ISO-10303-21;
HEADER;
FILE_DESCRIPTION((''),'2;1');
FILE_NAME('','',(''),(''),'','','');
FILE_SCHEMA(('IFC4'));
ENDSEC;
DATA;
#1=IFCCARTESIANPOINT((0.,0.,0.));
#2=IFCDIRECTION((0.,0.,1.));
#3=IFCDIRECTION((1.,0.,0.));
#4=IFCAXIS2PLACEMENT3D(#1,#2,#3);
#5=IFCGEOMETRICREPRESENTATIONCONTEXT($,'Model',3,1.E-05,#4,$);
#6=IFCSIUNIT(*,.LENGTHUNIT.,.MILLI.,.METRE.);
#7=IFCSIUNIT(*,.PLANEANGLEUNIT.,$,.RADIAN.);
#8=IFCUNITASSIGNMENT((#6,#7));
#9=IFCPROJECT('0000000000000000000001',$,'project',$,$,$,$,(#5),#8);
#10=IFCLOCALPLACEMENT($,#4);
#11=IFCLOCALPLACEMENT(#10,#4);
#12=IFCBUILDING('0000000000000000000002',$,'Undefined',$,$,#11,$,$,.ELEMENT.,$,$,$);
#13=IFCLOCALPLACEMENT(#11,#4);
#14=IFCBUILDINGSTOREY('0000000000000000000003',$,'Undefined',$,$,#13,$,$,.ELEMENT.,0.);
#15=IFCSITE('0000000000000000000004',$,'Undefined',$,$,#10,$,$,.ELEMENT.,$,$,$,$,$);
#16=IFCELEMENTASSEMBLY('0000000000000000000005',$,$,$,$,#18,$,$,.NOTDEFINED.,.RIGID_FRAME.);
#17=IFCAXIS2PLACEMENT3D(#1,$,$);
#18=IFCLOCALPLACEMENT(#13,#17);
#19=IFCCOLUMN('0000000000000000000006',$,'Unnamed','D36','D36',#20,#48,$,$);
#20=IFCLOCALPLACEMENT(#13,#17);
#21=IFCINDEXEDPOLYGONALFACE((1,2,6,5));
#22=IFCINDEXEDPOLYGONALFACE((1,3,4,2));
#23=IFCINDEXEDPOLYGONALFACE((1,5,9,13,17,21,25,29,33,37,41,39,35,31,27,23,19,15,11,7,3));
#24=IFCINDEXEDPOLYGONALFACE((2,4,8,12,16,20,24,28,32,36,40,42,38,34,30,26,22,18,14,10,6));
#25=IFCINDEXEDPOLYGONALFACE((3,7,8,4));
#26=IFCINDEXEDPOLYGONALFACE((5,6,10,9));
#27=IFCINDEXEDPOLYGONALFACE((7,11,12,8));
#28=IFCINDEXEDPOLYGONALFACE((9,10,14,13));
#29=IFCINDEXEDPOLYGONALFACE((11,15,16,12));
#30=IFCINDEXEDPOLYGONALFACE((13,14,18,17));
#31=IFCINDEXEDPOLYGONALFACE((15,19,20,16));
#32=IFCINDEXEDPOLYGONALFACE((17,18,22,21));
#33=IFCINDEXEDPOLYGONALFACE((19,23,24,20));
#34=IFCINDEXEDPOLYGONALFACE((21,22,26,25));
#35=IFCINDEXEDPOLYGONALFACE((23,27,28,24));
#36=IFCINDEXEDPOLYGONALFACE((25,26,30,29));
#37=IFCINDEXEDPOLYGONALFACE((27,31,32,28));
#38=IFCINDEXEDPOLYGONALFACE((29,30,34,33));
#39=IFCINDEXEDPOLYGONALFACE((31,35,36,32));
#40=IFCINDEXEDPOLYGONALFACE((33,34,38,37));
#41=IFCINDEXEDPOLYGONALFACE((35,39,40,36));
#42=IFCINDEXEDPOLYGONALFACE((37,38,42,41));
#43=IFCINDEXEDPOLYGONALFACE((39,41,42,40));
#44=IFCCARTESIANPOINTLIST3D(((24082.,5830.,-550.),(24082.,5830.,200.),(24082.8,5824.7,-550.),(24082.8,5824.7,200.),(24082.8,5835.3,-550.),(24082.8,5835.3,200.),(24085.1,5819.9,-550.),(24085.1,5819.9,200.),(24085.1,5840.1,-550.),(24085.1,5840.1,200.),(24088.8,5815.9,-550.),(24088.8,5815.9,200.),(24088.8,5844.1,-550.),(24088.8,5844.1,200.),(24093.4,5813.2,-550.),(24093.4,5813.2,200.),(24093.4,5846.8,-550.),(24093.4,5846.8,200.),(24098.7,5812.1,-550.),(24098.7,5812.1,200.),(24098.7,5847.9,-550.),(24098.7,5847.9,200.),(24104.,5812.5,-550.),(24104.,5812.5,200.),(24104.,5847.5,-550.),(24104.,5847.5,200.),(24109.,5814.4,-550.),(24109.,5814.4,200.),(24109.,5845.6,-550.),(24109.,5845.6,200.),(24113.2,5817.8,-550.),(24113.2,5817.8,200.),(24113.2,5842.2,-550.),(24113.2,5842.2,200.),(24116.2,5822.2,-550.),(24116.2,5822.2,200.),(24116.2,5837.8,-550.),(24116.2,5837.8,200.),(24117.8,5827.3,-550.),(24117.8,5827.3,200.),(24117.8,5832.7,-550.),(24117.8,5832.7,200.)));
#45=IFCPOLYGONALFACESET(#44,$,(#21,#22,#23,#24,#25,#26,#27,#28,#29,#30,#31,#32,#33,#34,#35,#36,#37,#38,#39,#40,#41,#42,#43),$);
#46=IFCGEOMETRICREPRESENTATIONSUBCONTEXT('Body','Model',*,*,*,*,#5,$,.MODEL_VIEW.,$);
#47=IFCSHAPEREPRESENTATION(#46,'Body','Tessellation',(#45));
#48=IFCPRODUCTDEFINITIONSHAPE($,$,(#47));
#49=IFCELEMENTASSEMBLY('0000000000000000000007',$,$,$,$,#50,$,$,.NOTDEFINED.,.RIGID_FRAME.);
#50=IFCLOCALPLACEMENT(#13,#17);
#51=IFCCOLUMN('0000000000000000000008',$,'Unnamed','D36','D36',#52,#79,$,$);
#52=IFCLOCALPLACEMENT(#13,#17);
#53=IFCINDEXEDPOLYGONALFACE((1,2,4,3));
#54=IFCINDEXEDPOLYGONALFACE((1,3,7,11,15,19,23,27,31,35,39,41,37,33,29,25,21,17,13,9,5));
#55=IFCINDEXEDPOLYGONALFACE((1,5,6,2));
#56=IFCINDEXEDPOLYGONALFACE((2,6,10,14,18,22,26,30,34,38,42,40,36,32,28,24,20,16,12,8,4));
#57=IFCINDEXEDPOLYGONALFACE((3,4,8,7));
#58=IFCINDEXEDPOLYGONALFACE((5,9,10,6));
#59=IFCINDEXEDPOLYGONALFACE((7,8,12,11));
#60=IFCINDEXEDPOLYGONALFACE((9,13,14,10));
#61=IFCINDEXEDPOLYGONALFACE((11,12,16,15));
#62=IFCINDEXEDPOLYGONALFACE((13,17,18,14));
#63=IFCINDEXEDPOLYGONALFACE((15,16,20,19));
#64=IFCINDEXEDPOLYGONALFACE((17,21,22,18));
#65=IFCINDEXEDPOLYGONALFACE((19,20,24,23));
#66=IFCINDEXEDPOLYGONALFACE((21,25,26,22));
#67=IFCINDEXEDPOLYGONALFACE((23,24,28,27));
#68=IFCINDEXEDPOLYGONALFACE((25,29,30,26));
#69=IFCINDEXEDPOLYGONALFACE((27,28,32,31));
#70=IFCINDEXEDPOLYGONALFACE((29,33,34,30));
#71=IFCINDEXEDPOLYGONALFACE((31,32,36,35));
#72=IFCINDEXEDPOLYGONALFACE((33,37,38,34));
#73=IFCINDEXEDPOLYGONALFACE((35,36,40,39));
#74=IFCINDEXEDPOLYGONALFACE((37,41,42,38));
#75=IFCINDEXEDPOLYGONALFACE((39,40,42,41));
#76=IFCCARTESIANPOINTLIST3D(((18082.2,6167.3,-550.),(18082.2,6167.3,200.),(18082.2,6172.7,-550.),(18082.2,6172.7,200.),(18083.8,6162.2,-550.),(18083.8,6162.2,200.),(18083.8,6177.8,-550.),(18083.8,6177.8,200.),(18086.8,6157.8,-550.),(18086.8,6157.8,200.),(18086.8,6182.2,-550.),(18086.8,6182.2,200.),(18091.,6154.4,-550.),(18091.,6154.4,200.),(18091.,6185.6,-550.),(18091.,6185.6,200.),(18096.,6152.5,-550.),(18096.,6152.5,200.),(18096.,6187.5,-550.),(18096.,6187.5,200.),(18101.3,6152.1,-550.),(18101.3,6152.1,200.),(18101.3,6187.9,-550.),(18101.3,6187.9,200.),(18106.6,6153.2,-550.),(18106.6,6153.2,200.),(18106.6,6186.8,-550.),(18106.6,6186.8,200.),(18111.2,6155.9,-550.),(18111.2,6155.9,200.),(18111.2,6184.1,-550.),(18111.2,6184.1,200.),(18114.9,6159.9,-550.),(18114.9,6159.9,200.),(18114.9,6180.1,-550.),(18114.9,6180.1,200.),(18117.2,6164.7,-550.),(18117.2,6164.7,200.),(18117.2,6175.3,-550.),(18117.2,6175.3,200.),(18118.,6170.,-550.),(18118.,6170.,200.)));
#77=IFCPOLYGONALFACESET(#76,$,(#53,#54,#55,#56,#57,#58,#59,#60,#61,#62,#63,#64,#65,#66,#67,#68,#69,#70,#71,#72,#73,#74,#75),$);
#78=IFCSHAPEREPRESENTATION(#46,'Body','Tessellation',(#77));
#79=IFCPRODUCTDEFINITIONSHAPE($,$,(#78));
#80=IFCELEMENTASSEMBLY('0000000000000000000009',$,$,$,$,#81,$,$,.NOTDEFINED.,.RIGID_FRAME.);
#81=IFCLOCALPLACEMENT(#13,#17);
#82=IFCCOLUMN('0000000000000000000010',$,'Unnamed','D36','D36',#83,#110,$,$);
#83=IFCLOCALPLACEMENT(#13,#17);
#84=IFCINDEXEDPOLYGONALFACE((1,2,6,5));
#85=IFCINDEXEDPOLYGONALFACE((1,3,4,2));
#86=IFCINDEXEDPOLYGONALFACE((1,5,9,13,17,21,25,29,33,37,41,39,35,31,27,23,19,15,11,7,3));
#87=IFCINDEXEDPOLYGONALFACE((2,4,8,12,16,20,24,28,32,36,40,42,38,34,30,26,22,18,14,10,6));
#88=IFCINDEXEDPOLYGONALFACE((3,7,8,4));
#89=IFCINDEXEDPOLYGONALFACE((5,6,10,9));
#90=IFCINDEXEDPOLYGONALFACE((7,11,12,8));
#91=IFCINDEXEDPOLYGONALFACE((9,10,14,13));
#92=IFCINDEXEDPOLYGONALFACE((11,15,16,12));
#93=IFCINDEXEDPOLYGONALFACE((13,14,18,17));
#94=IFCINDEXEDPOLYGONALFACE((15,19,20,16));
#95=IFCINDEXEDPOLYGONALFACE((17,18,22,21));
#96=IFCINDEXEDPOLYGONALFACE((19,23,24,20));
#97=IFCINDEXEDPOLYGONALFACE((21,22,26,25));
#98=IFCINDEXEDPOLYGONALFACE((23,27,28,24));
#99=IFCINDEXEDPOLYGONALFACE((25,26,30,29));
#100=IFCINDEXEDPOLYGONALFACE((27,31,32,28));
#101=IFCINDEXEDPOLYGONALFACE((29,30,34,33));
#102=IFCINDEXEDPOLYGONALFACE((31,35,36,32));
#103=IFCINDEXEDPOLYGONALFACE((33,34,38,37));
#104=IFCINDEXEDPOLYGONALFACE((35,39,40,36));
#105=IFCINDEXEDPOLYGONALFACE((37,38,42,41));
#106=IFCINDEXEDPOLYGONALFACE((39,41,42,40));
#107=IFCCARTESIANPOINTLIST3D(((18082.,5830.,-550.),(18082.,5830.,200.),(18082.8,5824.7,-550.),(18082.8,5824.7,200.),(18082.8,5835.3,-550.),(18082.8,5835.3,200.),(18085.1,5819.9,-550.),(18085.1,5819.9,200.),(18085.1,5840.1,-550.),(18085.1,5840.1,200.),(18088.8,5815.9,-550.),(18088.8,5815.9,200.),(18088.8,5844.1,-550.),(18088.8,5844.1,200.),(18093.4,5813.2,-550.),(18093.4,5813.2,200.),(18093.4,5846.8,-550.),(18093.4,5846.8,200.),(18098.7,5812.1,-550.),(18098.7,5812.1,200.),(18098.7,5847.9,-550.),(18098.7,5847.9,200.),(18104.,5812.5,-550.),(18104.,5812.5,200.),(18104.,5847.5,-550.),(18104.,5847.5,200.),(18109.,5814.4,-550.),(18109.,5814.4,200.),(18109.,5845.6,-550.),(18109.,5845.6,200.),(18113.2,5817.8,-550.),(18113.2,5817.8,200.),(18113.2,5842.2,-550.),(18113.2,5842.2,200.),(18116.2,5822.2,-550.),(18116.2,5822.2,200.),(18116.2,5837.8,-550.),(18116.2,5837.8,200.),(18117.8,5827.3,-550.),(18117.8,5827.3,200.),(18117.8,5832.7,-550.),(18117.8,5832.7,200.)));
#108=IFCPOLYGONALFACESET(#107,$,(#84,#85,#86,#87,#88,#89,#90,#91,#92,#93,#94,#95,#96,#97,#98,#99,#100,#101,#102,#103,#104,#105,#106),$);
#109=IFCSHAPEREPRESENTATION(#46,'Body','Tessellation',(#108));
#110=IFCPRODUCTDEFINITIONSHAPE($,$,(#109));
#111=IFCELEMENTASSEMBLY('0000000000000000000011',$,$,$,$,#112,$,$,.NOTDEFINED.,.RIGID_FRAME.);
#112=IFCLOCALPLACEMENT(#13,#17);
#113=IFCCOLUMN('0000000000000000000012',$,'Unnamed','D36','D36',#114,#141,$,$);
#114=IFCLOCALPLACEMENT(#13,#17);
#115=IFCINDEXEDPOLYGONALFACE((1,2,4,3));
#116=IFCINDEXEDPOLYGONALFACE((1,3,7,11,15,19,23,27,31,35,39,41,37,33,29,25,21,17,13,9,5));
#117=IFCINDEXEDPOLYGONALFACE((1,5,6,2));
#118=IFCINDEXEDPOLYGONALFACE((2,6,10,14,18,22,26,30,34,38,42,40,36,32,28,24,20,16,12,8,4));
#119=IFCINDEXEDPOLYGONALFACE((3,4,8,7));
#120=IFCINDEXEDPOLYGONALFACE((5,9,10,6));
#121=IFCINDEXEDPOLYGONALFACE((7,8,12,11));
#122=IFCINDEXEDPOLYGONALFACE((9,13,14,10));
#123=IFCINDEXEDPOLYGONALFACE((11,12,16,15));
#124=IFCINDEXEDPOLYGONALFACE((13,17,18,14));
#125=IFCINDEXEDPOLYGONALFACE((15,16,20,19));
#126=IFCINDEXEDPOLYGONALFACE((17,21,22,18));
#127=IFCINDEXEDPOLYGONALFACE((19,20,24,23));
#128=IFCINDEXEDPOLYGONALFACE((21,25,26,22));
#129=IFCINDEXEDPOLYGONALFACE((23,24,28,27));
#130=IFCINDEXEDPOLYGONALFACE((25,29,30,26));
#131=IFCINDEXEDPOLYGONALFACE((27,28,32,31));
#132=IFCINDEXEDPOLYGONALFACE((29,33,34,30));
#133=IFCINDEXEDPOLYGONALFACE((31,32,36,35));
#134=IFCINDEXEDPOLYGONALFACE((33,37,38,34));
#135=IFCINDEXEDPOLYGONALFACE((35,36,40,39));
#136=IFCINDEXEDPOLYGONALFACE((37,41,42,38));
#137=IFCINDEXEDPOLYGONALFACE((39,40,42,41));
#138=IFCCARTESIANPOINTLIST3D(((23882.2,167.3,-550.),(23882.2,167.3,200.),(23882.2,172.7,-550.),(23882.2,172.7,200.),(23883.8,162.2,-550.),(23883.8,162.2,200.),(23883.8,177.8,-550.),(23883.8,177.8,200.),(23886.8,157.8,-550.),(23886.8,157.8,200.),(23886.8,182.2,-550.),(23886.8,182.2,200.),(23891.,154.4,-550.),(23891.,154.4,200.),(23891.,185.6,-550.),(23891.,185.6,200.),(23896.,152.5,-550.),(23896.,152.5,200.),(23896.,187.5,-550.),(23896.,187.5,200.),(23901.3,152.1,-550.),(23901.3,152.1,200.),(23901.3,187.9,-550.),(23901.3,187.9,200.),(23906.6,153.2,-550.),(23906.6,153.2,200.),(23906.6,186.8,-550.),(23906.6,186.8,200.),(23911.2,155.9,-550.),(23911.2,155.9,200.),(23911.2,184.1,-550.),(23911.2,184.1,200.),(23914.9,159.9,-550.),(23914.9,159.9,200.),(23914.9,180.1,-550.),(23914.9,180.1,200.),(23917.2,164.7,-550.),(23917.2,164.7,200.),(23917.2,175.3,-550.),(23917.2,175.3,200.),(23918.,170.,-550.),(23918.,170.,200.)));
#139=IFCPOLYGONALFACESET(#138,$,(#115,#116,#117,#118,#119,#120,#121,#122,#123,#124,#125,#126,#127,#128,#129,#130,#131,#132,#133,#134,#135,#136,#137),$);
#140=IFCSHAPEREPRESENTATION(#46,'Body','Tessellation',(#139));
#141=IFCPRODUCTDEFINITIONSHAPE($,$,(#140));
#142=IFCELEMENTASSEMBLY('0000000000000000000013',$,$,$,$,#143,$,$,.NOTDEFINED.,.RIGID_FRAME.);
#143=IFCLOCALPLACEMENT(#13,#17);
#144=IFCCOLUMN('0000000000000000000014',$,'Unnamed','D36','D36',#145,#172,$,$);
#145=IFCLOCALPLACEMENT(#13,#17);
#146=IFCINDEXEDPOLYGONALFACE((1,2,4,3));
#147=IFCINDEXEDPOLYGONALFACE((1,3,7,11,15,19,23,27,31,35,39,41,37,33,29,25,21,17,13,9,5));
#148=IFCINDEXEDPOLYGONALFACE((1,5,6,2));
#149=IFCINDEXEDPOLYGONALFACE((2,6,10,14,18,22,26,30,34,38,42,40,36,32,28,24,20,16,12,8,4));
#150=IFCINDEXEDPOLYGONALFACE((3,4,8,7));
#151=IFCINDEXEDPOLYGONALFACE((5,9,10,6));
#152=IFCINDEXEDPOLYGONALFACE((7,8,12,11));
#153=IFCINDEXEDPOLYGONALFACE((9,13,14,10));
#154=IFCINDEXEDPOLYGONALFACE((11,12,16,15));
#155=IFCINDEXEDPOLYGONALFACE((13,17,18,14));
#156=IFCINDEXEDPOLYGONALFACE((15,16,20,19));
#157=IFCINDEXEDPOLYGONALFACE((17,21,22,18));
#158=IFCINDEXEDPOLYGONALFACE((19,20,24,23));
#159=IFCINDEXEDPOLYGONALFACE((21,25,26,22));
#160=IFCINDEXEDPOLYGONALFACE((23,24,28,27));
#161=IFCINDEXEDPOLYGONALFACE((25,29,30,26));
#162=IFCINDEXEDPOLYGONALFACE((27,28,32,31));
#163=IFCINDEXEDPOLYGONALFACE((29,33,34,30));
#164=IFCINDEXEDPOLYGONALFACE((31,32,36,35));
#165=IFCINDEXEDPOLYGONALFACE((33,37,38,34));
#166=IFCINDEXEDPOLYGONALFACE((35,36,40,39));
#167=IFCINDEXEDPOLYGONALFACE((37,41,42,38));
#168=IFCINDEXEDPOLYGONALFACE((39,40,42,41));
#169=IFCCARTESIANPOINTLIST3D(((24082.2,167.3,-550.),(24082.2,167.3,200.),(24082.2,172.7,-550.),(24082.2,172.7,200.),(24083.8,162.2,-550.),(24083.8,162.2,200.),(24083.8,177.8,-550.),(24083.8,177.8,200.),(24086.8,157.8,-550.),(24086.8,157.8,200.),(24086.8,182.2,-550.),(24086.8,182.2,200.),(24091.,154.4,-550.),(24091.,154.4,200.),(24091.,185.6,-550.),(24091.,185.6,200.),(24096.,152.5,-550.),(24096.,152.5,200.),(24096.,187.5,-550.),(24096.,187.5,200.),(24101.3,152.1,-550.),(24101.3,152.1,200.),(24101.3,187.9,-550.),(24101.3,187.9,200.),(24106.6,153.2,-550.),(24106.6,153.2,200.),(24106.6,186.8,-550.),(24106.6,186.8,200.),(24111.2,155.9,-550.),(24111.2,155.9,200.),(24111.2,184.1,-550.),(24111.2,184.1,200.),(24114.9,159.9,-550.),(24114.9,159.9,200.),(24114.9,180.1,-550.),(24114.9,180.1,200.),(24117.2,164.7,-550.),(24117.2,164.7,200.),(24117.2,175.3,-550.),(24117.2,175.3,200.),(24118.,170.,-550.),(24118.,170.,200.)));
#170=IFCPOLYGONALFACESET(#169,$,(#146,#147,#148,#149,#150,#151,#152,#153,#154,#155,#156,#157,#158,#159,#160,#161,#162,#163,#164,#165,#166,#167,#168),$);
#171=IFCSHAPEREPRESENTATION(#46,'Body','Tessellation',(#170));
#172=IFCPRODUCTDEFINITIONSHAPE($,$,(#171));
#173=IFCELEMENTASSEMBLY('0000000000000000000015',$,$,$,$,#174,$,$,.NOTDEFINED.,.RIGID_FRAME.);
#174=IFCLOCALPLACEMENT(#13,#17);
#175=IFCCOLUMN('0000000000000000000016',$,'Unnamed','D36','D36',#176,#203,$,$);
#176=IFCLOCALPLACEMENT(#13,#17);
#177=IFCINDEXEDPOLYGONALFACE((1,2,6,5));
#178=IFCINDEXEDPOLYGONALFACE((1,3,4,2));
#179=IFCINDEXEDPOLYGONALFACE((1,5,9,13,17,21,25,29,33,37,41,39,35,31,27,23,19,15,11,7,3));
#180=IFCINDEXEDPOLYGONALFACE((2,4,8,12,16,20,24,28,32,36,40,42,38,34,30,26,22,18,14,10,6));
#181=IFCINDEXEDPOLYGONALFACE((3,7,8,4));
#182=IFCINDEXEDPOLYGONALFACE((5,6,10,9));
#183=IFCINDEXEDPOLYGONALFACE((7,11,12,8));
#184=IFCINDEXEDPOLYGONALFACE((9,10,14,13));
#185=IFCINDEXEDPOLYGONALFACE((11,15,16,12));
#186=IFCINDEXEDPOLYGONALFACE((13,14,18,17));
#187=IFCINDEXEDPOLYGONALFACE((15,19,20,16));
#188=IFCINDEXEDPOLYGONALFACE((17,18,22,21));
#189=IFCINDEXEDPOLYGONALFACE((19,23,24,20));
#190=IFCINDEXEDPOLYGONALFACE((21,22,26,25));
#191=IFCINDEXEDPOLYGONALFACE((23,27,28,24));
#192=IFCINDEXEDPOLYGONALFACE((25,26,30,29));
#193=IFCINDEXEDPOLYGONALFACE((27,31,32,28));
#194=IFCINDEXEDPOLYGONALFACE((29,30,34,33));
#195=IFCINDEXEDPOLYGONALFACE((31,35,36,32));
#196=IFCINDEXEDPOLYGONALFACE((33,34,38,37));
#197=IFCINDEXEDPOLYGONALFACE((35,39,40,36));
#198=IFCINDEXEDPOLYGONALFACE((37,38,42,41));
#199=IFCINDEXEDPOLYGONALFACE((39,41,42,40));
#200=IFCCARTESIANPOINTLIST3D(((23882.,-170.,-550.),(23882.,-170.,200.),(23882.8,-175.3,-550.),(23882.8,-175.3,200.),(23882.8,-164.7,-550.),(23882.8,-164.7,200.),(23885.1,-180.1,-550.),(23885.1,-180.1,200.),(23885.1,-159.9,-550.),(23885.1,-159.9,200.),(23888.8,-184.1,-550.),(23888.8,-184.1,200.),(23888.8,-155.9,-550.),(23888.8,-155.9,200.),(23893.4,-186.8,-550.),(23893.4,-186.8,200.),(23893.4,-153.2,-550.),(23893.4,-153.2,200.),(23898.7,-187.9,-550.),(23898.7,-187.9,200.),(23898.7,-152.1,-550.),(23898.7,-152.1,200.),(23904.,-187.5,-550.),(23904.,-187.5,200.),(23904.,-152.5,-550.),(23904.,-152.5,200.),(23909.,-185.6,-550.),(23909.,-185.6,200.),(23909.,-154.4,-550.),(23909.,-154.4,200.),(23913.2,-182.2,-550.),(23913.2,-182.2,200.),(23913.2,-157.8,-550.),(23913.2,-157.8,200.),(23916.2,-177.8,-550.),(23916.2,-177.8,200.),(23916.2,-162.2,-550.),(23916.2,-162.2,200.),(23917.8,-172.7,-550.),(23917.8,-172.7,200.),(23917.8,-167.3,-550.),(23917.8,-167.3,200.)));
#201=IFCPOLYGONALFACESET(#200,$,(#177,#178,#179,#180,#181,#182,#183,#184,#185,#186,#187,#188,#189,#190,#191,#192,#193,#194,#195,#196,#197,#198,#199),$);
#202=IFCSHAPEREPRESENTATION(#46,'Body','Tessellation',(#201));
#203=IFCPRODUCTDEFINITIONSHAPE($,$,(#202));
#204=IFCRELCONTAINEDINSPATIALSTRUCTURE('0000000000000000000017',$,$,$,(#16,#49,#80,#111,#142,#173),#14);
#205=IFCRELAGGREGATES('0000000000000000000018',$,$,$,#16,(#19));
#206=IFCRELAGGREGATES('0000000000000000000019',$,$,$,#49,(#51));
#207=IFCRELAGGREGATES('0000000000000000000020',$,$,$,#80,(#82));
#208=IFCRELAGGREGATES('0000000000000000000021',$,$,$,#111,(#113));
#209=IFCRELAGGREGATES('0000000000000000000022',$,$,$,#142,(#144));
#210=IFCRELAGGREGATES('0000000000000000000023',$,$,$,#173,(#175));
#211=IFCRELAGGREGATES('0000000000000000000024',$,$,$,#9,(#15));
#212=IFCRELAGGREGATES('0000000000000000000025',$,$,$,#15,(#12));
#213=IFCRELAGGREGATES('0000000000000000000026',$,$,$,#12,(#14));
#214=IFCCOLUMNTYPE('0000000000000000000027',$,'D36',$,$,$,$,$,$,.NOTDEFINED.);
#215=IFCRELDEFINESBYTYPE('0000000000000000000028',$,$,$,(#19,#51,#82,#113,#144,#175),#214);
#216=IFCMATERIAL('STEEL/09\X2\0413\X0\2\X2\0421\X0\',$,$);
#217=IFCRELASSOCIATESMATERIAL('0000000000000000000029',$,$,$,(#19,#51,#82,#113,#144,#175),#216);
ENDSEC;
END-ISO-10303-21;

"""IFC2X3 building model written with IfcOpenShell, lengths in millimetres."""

from ifc_helpers import new_model, si_unit, frame, origin_with_axes, origin_2d_with_axis, place, context, subcontext, project, spatial, circle, extrude, material, type_object, element, aggregate, save


model = new_model("IFC2X3")

# Units and contexts
model_context = context("Model", 3, precision=1e-05, world=origin_with_axes())
body_context = subcontext(model_context, "Body", "Model", "MODEL_VIEW")
ifc_project = project(units=[si_unit("LENGTHUNIT", "METRE", prefix="MILLI"), si_unit("PLANEANGLEUNIT", "RADIAN")], contexts=[model_context])

# Site, building, storey
site_placement = place(None, origin_with_axes())
site = spatial("IfcSite", under=ifc_project, at=site_placement, Name="Undefined", CompositionType="ELEMENT")
building_placement = place(site_placement, origin_with_axes())
building = spatial("IfcBuilding", under=site, at=building_placement, Name="Undefined", CompositionType="ELEMENT")
storey_placement = place(building_placement, origin_with_axes())
storey = spatial("IfcBuildingStorey", under=building, at=storey_placement, Name="Undefined", CompositionType="ELEMENT", Elevation=0.0)

# Element assemblies, columns
ifc_material_1 = material(Name="STEEL/09Г2С")
column_type_1 = type_object("IfcColumnType", Name="D36", PredefinedType="NOTDEFINED")
assembly_1_placement = place(storey_placement, origin_with_axes())
assembly_1 = element("IfcElementAssembly", 1, at=assembly_1_placement, inside=storey, AssemblyPlace="NOTDEFINED", PredefinedType="RIGID_FRAME")
column_1_placement = place(assembly_1_placement, frame((24100.0, 5830.0, -550.0), z_axis=(0.0, 0.0, 1.0), x_axis=(0.0, 1.0, 0.0)))
column_1 = element("IfcColumn", 2, at=column_1_placement, type_object=column_type_1, material=ifc_material_1, Name="Unnamed", Description="D36", ObjectType="D36", context=body_context, shape_type="SweptSolid", body=[
    extrude(circle(Radius=18.0, at=origin_2d_with_axis()), frame((0.0, 0.0, 750.0), z_axis=(0.0, 0.0, -1.0), x_axis=(0.0, 1.0, 0.0)), (0.0, 0.0, 1.0), 750.0),
])
aggregate(assembly_1, [column_1])
assembly_2_placement = place(storey_placement, origin_with_axes())
assembly_2 = element("IfcElementAssembly", 3, at=assembly_2_placement, inside=storey, AssemblyPlace="NOTDEFINED", PredefinedType="RIGID_FRAME")
column_2_placement = place(assembly_2_placement, frame((18100.0, 6170.0, -550.0), z_axis=(0.0, 0.0, 1.0), x_axis=(0.0, -1.0, 0.0)))
column_2 = element("IfcColumn", 4, at=column_2_placement, type_object=column_type_1, material=ifc_material_1, Name="Unnamed", Description="D36", ObjectType="D36", context=body_context, shape_type="SweptSolid", body=[
    extrude(circle(Radius=18.0, at=origin_2d_with_axis()), frame((0.0, 0.0, 750.0), z_axis=(0.0, 0.0, -1.0), x_axis=(0.0, 1.0, 0.0)), (0.0, 0.0, 1.0), 750.0),
])
aggregate(assembly_2, [column_2])
assembly_3_placement = place(storey_placement, origin_with_axes())
assembly_3 = element("IfcElementAssembly", 5, at=assembly_3_placement, inside=storey, AssemblyPlace="NOTDEFINED", PredefinedType="RIGID_FRAME")
column_3_placement = place(assembly_3_placement, frame((18100.0, 5830.0, -550.0), z_axis=(0.0, 0.0, 1.0), x_axis=(0.0, 1.0, 0.0)))
column_3 = element("IfcColumn", 6, at=column_3_placement, type_object=column_type_1, material=ifc_material_1, Name="Unnamed", Description="D36", ObjectType="D36", context=body_context, shape_type="SweptSolid", body=[
    extrude(circle(Radius=18.0, at=origin_2d_with_axis()), frame((0.0, 0.0, 750.0), z_axis=(0.0, 0.0, -1.0), x_axis=(0.0, 1.0, 0.0)), (0.0, 0.0, 1.0), 750.0),
])
aggregate(assembly_3, [column_3])
assembly_4_placement = place(storey_placement, origin_with_axes())
assembly_4 = element("IfcElementAssembly", 7, at=assembly_4_placement, inside=storey, AssemblyPlace="NOTDEFINED", PredefinedType="RIGID_FRAME")
column_4_placement = place(assembly_4_placement, frame((23900.0, 170.0, -550.0), z_axis=(0.0, 0.0, 1.0), x_axis=(0.0, -1.0, 0.0)))
column_4 = element("IfcColumn", 8, at=column_4_placement, type_object=column_type_1, material=ifc_material_1, Name="Unnamed", Description="D36", ObjectType="D36", context=body_context, shape_type="SweptSolid", body=[
    extrude(circle(Radius=18.0, at=origin_2d_with_axis()), frame((0.0, 0.0, 750.0), z_axis=(0.0, 0.0, -1.0), x_axis=(0.0, 1.0, 0.0)), (0.0, 0.0, 1.0), 750.0),
])
aggregate(assembly_4, [column_4])
assembly_5_placement = place(storey_placement, origin_with_axes())
assembly_5 = element("IfcElementAssembly", 9, at=assembly_5_placement, inside=storey, AssemblyPlace="NOTDEFINED", PredefinedType="RIGID_FRAME")
column_5_placement = place(assembly_5_placement, frame((24100.0, 170.0, -550.0), z_axis=(0.0, 0.0, 1.0), x_axis=(0.0, -1.0, 0.0)))
column_5 = element("IfcColumn", 10, at=column_5_placement, type_object=column_type_1, material=ifc_material_1, Name="Unnamed", Description="D36", ObjectType="D36", context=body_context, shape_type="SweptSolid", body=[
    extrude(circle(Radius=18.0, at=origin_2d_with_axis()), frame((0.0, 0.0, 750.0), z_axis=(0.0, 0.0, -1.0), x_axis=(0.0, 1.0, 0.0)), (0.0, 0.0, 1.0), 750.0),
])
aggregate(assembly_5, [column_5])
assembly_6_placement = place(storey_placement, origin_with_axes())
assembly_6 = element("IfcElementAssembly", 11, at=assembly_6_placement, inside=storey, AssemblyPlace="NOTDEFINED", PredefinedType="RIGID_FRAME")
column_6_placement = place(assembly_6_placement, frame((23900.0, -170.0, -550.0), z_axis=(0.0, 0.0, 1.0), x_axis=(0.0, 1.0, 0.0)))
column_6 = element("IfcColumn", 12, at=column_6_placement, type_object=column_type_1, material=ifc_material_1, Name="Unnamed", Description="D36", ObjectType="D36", context=body_context, shape_type="SweptSolid", body=[
    extrude(circle(Radius=18.0, at=origin_2d_with_axis()), frame((0.0, 0.0, 750.0), z_axis=(0.0, 0.0, -1.0), x_axis=(0.0, 1.0, 0.0)), (0.0, 0.0, 1.0), 750.0),
])
aggregate(assembly_6, [column_6])

save(model, "model.ifc")
